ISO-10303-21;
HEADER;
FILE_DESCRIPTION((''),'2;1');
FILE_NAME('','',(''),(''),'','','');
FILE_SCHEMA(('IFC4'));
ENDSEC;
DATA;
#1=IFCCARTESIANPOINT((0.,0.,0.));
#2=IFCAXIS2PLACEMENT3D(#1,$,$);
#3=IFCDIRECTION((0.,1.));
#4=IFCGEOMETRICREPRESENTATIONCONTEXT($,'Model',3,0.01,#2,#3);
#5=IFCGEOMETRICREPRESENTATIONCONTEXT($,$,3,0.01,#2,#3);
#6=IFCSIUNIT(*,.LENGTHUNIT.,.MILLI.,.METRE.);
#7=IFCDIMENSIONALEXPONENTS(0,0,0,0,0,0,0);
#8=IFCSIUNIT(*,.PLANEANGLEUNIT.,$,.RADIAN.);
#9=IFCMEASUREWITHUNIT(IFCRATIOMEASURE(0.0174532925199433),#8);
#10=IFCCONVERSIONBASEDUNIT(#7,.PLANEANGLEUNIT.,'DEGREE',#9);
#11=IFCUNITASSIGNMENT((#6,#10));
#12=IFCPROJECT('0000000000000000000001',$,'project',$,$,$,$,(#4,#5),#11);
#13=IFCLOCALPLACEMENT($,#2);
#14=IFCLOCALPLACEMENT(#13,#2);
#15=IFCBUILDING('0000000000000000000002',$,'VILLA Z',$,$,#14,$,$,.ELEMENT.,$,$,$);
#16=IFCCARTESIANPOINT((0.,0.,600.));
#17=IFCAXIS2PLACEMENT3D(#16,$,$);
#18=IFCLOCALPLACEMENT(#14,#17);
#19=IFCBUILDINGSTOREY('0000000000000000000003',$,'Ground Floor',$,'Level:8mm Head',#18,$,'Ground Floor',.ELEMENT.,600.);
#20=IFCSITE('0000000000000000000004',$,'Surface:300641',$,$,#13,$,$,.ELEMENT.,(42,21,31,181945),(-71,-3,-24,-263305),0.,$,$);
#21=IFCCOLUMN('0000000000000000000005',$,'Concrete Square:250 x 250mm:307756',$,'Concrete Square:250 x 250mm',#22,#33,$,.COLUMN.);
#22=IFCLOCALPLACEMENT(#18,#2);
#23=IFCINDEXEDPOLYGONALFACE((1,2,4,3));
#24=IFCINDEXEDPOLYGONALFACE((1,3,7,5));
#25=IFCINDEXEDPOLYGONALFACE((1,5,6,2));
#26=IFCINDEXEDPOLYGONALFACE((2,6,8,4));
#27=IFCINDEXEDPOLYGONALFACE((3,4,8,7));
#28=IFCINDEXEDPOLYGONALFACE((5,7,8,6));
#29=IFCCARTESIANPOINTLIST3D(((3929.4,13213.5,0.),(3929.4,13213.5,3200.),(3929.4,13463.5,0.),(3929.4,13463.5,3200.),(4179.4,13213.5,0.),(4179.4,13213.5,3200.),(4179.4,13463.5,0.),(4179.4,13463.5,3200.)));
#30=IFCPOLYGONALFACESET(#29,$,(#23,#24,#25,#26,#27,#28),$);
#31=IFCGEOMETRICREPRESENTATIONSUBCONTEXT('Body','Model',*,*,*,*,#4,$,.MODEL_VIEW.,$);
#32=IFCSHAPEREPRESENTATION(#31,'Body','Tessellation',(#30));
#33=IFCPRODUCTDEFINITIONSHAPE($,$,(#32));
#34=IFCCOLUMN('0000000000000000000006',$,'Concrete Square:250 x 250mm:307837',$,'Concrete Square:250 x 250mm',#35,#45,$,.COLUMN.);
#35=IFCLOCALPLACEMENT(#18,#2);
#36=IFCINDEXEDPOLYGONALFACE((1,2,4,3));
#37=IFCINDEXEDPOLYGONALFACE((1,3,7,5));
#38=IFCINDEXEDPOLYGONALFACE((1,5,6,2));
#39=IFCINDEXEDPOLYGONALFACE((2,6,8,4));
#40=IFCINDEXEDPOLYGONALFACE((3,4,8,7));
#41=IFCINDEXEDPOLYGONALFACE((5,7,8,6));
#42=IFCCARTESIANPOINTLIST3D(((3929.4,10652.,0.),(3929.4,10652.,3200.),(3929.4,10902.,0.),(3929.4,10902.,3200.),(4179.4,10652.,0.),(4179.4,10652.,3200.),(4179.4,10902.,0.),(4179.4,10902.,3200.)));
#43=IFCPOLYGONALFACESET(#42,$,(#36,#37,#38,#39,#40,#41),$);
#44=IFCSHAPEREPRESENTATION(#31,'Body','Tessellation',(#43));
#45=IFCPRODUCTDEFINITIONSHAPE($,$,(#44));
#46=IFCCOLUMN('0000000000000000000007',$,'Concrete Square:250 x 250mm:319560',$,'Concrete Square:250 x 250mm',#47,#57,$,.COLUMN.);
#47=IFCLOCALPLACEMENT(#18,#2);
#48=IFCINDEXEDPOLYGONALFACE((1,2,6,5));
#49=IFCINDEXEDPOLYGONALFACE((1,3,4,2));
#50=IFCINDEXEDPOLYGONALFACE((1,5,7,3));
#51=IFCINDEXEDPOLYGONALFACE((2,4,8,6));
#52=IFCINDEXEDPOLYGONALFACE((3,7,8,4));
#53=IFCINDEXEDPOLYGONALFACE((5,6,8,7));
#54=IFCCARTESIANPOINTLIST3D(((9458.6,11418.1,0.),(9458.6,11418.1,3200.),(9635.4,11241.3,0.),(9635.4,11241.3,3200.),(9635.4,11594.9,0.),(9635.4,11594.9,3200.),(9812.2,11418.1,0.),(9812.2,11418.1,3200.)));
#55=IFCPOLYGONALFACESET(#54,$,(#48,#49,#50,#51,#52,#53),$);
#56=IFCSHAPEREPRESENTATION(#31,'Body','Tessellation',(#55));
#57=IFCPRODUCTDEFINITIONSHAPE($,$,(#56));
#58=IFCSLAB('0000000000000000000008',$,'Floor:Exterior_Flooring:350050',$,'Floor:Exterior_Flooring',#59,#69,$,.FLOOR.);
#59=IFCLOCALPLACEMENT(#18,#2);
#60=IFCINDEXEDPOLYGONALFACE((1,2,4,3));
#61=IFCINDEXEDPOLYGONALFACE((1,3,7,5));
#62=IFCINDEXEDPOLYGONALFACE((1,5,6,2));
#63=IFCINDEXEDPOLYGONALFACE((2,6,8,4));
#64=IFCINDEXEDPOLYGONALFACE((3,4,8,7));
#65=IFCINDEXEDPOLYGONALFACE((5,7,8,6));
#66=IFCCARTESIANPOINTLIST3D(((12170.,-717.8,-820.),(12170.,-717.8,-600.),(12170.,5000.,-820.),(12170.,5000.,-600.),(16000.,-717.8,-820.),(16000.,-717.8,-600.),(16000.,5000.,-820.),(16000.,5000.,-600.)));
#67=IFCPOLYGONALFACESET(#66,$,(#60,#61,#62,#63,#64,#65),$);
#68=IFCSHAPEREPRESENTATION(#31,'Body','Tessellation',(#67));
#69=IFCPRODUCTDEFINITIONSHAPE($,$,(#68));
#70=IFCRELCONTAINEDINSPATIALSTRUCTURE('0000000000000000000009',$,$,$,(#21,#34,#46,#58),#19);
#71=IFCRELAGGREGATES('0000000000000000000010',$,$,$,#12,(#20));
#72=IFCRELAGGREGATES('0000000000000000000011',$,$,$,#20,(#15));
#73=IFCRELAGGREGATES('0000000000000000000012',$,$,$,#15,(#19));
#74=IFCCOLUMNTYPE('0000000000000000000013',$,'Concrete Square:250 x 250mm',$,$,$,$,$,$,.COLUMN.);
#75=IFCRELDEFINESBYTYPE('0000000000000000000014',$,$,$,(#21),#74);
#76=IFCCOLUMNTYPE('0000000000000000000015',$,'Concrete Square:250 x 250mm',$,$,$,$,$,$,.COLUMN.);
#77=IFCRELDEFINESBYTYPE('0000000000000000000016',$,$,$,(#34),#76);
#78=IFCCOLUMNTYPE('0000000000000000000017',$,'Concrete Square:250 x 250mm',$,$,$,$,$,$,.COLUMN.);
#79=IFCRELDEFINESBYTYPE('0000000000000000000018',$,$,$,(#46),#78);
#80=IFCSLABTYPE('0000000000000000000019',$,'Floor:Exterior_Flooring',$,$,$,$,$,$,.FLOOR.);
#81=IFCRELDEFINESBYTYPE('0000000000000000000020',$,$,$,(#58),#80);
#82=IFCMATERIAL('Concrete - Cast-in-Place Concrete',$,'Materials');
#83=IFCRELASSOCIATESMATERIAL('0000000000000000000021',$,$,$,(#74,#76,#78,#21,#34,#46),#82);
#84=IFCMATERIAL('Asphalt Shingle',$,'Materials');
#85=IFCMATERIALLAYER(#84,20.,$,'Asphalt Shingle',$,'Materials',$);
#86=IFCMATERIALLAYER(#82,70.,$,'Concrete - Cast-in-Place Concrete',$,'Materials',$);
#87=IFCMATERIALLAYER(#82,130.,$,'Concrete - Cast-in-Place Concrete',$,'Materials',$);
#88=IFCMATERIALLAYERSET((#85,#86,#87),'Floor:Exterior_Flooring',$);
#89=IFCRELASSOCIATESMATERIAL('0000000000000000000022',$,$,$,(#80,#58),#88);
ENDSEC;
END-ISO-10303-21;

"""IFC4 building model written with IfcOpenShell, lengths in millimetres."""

from ifc_helpers import new_model, entity, si_unit, converted_unit, direction, frame, frame_2d, origin, place, context, subcontext, project, spatial, rectangle, extrude, source, transform, mapped, material, layer, layer_set, layer_usage, material_profile, profile_set, profile_usage, type_object, type_shapes, element, save


model = new_model("IFC4")

# Units and contexts
model_context = context("Model", 3, precision=0.01, world=origin(), true_north=direction((0.0, 1.0)))
context_of_model = context(None, 3, precision=0.01, world=origin(), true_north=direction((0.0, 1.0)))
body_context = subcontext(model_context, "Body", "Model", "MODEL_VIEW")
ifc_project = project(units=[si_unit("LENGTHUNIT", "METRE", prefix="MILLI"), converted_unit("PLANEANGLEUNIT", "DEGREE", entity("IfcRatioMeasure", 0.0174532925199433), si_unit("PLANEANGLEUNIT", "RADIAN"), dimensions=[0, 0, 0, 0, 0, 0, 0])], contexts=[model_context, context_of_model])

# Site, building, storey
site_placement = place(None, origin())
site = spatial("IfcSite", under=ifc_project, at=site_placement, Name="Surface:300641", CompositionType="ELEMENT", RefLatitude=(42, 21, 31, 181945), RefLongitude=(-71, -3, -24, -263305), RefElevation=0.0)
building_placement = place(site_placement, origin())
building = spatial("IfcBuilding", under=site, at=building_placement, Name="VILLA Z", CompositionType="ELEMENT")
storey_placement = place(building_placement, frame((0.0, 0.0, 600.0)))
storey = spatial("IfcBuildingStorey", under=building, at=storey_placement, Name="Ground Floor", ObjectType="Level:8mm Head", LongName="Ground Floor", CompositionType="ELEMENT", Elevation=600.0)

# Columns
ifc_material_1 = material(Name="Concrete - Cast-in-Place Concrete", Category="Materials")
ifc_material_profile_1 = material_profile(ifc_material_1, rectangle(XDim=250.0, YDim=250.0, at=frame_2d((0.0, 0.0), x_axis=(1.0, 0.0))), Name="250 x 250mm")
ifc_profile_set_1 = profile_set([ifc_material_profile_1], Name="250 x 250mm")
ifc_profile_usage_1 = profile_usage(ifc_profile_set_1)
column_type_1 = type_object("IfcColumnType", Name="Concrete Square:250 x 250mm", PredefinedType="COLUMN", material=ifc_profile_set_1)
shared_shape_1 = source(origin(), body_context, "Body", "SweptSolid", [
    extrude(rectangle(XDim=250.0, YDim=250.0, at=frame_2d((0.0, 0.0), x_axis=(1.0, 0.0))), frame((4054.4, 13338.5, 600.0), z_axis=(0.0, 0.0, 1.0), x_axis=(0.0, -1.0, 0.0)), (0.0, 0.0, 1.0), 3200.0),
])
type_shapes(column_type_1, [shared_shape_1])
column_1_placement = place(storey_placement, frame((0.0, 0.0, -600.0)))
element("IfcColumn", 1, at=column_1_placement, inside=storey, type_object=column_type_1, material=ifc_profile_usage_1, Name="Concrete Square:250 x 250mm:307756", ObjectType="Concrete Square:250 x 250mm", PredefinedType="COLUMN", context=body_context, shape_type="MappedRepresentation", body=[
    mapped(shared_shape_1, transform((0.0, 0.0, 0.0), scale=1.0)),
])
ifc_profile_usage_2 = profile_usage(ifc_profile_set_1)
column_type_2 = type_object("IfcColumnType", Name="Concrete Square:250 x 250mm", PredefinedType="COLUMN", material=ifc_profile_set_1)
shared_shape_2 = source(origin(), body_context, "Body", "SweptSolid", [
    extrude(rectangle(XDim=250.0, YDim=250.0, at=frame_2d((0.0, 0.0), x_axis=(1.0, 0.0))), frame((4054.4, 10777.0, 600.0), z_axis=(0.0, 0.0, 1.0), x_axis=(0.0, -1.0, 0.0)), (0.0, 0.0, 1.0), 3200.0),
])
type_shapes(column_type_2, [shared_shape_2])
column_2_placement = place(storey_placement, frame((0.0, 0.0, -600.0)))
element("IfcColumn", 2, at=column_2_placement, inside=storey, type_object=column_type_2, material=ifc_profile_usage_2, Name="Concrete Square:250 x 250mm:307837", ObjectType="Concrete Square:250 x 250mm", PredefinedType="COLUMN", context=body_context, shape_type="MappedRepresentation", body=[
    mapped(shared_shape_2, transform((0.0, 0.0, 0.0), scale=1.0)),
])
ifc_profile_usage_3 = profile_usage(ifc_profile_set_1)
column_type_3 = type_object("IfcColumnType", Name="Concrete Square:250 x 250mm", PredefinedType="COLUMN", material=ifc_profile_set_1)
shared_shape_3 = source(origin(), body_context, "Body", "SweptSolid", [
    extrude(rectangle(XDim=250.0, YDim=250.0, at=frame_2d((0.0, 0.0), x_axis=(1.0, 0.0))), frame((9635.4, 11418.1, 600.0), z_axis=(0.0, 0.0, 1.0), x_axis=(-0.707107, 0.707107, 0.0)), (0.0, 0.0, 1.0), 3200.0),
])
type_shapes(column_type_3, [shared_shape_3])
column_3_placement = place(storey_placement, frame((0.0, 0.0, -600.0)))
element("IfcColumn", 3, at=column_3_placement, inside=storey, type_object=column_type_3, material=ifc_profile_usage_3, Name="Concrete Square:250 x 250mm:319560", ObjectType="Concrete Square:250 x 250mm", PredefinedType="COLUMN", context=body_context, shape_type="MappedRepresentation", body=[
    mapped(shared_shape_3, transform((0.0, 0.0, 0.0), scale=1.0)),
])

# Slab
ifc_material_2 = material(Name="Asphalt Shingle", Category="Materials")
ifc_layer_1 = layer(ifc_material_2, 20.0, Name="Asphalt Shingle", Category="Materials")
ifc_layer_2 = layer(ifc_material_1, 70.0, Name="Concrete - Cast-in-Place Concrete", Category="Materials")
ifc_layer_3 = layer(ifc_material_1, 130.0, Name="Concrete - Cast-in-Place Concrete", Category="Materials")
ifc_layer_set_1 = layer_set([ifc_layer_1, ifc_layer_2, ifc_layer_3], Name="Floor:Exterior_Flooring")
ifc_layer_usage_1 = layer_usage(ifc_layer_set_1, "AXIS3", "POSITIVE", 0.0)
slab_type_1 = type_object("IfcSlabType", Name="Floor:Exterior_Flooring", PredefinedType="FLOOR", material=ifc_layer_set_1)
slab_1_placement = place(storey_placement, origin())
element("IfcSlab", 4, at=slab_1_placement, inside=storey, type_object=slab_type_1, material=ifc_layer_usage_1, Name="Floor:Exterior_Flooring:350050", ObjectType="Floor:Exterior_Flooring", PredefinedType="FLOOR", context=body_context, shape_type="SweptSolid", body=[
    extrude(rectangle(XDim=5717.8, YDim=3830.0, at=frame_2d((0.0, 0.0), x_axis=(1.0, 0.0))), frame((14085.0, 2141.1, -600.0), z_axis=(0.0, 0.0, -1.0), x_axis=(0.0, 1.0, 0.0)), (0.0, 0.0, 1.0), 220.0),
])

save(model, "model.ifc")
